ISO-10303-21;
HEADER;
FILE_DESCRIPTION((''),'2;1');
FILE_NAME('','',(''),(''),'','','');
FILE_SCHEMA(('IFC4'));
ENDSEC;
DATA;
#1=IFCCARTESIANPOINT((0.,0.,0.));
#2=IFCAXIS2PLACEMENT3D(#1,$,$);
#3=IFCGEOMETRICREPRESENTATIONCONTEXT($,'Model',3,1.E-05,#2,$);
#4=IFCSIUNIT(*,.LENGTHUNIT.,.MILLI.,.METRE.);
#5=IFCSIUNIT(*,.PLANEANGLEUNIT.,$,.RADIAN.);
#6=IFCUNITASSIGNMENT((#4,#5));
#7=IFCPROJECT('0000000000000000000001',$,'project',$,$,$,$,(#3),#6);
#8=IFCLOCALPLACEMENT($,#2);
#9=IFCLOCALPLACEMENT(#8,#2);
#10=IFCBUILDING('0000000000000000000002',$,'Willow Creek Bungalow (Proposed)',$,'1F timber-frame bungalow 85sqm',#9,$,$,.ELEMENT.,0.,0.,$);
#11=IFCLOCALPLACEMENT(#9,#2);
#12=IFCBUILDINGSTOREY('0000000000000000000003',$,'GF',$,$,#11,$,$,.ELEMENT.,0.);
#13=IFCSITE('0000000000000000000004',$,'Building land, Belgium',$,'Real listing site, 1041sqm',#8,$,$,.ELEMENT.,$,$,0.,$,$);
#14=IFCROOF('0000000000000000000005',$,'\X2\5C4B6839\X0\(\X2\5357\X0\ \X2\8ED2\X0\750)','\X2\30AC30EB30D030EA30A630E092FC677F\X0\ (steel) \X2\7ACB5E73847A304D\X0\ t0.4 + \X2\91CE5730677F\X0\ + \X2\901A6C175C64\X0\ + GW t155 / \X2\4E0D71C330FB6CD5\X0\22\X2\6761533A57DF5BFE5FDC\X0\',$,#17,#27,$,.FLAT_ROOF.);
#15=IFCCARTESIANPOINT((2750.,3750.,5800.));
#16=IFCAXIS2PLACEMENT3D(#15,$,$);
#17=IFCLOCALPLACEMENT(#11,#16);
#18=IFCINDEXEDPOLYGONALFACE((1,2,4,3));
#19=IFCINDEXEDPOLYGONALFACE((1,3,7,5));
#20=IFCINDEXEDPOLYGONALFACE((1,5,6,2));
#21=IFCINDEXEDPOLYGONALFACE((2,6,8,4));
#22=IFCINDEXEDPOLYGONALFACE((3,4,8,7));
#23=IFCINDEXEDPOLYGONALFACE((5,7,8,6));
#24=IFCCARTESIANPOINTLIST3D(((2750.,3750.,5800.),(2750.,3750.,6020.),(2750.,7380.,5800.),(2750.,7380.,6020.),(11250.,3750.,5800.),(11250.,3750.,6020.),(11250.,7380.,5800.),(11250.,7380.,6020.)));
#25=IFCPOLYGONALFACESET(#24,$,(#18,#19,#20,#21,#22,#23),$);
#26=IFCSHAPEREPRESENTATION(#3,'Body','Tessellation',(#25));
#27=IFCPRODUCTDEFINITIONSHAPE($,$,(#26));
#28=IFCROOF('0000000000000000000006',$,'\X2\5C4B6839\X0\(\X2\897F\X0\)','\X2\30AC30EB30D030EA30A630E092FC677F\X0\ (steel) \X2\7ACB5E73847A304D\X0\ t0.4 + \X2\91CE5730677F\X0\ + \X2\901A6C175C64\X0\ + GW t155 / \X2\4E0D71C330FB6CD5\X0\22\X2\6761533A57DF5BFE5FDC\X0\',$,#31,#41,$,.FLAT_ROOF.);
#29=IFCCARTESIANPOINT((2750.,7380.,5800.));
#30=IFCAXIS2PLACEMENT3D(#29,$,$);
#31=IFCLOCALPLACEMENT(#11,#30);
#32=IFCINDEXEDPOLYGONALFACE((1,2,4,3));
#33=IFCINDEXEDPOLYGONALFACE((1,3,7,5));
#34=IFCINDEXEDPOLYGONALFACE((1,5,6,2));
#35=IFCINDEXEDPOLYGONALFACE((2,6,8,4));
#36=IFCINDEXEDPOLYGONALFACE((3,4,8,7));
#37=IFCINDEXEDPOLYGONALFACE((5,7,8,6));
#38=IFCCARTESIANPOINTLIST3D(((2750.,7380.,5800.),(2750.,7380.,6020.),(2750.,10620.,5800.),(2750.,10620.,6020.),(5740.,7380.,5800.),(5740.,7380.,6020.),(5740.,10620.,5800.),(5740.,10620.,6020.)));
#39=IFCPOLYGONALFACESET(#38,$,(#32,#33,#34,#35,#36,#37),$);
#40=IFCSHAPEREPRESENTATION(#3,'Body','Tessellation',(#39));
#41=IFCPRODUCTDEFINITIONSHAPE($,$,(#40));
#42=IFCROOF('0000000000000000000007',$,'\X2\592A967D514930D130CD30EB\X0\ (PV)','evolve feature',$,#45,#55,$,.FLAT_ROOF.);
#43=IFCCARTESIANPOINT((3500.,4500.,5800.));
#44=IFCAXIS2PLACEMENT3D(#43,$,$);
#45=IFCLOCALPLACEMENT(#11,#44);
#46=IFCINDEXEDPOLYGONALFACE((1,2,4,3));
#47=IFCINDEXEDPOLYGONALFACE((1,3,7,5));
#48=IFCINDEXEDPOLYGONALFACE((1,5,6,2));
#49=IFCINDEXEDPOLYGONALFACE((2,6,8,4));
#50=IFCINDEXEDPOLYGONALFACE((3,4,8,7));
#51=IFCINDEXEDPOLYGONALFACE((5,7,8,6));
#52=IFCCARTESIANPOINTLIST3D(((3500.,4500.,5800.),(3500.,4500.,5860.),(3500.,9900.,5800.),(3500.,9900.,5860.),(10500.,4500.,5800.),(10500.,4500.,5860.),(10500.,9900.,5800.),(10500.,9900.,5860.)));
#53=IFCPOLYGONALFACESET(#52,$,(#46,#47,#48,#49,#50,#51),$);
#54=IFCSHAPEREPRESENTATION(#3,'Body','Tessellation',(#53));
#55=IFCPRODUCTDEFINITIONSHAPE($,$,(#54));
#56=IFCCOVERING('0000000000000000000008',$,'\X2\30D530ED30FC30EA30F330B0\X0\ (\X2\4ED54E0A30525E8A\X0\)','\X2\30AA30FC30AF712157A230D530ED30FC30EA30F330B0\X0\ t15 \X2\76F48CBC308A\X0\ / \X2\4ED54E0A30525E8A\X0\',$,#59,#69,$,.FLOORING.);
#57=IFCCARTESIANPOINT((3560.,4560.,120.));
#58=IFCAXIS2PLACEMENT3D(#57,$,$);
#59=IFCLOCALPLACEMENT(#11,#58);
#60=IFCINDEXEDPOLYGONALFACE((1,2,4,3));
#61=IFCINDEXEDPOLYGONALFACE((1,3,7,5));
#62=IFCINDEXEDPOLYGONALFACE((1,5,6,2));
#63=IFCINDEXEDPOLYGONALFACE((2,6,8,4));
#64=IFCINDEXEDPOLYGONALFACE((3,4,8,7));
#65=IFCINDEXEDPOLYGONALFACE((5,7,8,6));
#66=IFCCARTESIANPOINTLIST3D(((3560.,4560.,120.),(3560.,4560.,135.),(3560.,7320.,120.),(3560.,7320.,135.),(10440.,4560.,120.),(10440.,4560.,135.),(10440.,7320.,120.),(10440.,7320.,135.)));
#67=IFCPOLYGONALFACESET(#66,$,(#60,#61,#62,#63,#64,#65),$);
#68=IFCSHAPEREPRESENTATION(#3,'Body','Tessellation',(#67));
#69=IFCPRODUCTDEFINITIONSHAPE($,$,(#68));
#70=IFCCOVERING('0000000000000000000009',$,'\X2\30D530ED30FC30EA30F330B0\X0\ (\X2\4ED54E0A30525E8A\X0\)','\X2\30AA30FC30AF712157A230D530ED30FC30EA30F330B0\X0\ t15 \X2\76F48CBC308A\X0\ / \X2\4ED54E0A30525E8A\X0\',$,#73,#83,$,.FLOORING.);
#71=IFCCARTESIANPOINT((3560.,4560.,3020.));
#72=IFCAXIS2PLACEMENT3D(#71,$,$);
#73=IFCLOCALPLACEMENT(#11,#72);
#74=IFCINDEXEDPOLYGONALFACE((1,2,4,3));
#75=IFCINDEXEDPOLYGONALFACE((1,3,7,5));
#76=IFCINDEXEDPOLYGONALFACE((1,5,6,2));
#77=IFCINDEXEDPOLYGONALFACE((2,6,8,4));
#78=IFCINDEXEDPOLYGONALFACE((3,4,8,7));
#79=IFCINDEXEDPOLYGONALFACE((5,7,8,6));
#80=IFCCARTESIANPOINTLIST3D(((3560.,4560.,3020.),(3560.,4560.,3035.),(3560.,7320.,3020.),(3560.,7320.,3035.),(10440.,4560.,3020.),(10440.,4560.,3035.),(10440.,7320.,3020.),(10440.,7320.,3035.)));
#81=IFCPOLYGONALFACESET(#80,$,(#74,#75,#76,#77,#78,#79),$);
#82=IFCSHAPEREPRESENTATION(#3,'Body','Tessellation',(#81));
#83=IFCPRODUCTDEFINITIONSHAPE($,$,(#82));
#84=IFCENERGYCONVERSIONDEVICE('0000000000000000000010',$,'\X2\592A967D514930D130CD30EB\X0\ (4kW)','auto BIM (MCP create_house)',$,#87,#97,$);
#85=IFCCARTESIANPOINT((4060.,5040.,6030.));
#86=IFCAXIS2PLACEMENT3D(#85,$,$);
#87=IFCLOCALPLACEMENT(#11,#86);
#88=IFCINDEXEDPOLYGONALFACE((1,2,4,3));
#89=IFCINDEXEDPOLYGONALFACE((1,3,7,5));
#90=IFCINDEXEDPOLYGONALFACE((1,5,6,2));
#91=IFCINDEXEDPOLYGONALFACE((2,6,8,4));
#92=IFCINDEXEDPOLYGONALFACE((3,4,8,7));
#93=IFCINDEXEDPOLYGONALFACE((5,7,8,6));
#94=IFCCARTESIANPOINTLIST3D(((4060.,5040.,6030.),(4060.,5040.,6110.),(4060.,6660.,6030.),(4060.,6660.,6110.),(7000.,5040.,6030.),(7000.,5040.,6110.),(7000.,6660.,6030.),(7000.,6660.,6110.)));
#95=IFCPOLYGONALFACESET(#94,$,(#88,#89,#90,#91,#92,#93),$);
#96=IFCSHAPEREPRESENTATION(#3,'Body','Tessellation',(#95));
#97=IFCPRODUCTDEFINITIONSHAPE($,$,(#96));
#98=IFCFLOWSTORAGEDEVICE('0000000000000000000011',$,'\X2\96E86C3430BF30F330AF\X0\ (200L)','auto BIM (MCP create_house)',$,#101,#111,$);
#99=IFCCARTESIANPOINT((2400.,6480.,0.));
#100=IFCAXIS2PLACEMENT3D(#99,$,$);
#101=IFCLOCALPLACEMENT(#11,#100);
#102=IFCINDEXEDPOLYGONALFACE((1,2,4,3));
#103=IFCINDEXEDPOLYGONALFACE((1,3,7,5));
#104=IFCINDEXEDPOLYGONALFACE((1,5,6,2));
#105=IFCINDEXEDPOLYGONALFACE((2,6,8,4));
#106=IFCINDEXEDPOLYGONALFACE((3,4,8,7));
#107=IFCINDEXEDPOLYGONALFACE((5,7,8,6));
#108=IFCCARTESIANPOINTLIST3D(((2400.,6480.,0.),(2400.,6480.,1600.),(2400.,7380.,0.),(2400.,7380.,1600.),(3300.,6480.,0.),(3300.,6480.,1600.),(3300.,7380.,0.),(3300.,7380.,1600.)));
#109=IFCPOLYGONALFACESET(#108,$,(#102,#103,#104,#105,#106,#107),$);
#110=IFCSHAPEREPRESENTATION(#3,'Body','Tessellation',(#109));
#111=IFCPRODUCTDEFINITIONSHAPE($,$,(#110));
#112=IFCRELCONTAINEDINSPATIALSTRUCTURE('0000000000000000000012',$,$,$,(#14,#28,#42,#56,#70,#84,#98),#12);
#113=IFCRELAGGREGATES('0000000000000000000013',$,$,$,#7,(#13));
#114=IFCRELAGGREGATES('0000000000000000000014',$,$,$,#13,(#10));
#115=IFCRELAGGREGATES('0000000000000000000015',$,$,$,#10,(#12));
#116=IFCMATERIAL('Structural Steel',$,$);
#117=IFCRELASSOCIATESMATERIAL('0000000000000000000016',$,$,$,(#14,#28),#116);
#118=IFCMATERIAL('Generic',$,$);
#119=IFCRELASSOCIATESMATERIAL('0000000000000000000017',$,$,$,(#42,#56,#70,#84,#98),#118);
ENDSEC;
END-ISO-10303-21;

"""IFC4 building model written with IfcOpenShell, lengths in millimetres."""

from ifc_helpers import new_model, si_unit, frame, frame_2d, origin, place, context, project, spatial, rectangle, extrude, material, element, save


model = new_model("IFC4")

# Units and contexts
model_context = context("Model", 3, precision=1e-05, world=origin())
ifc_project = project(units=[si_unit("LENGTHUNIT", "METRE", prefix="MILLI"), si_unit("PLANEANGLEUNIT", "RADIAN")], contexts=[model_context])

# Site, building, storey
site_placement = place(None, origin())
site = spatial("IfcSite", under=ifc_project, at=site_placement, Name="Building land, Belgium", ObjectType="Real listing site, 1041sqm", CompositionType="ELEMENT", RefElevation=0.0)
building_placement = place(site_placement, origin())
building = spatial("IfcBuilding", under=site, at=building_placement, Name="Willow Creek Bungalow (Proposed)", ObjectType="1F timber-frame bungalow 85sqm", CompositionType="ELEMENT", ElevationOfRefHeight=0.0, ElevationOfTerrain=0.0)
storey_placement = place(building_placement, origin())
storey = spatial("IfcBuildingStorey", under=building, at=storey_placement, Name="GF", CompositionType="ELEMENT", Elevation=0.0)

# Shared definitions
ifc_material_1 = material(Name="Generic")

# Roofs
ifc_material_2 = material(Name="Structural Steel")
roof_1_placement = place(storey_placement, frame((2750.0, 3750.0, 5800.0)))
element("IfcRoof", 1, at=roof_1_placement, inside=storey, material=ifc_material_2, Name="屋根(南 軒750)", Description="ガルバリウム鋼板 (steel) 立平葺き t0.4 + 野地板 + 通気層 + GW t155 / 不燃・法22条区域対応", PredefinedType="FLAT_ROOF", context=model_context, shape_type="SweptSolid", body=[
    extrude(rectangle(XDim=8500.0, YDim=3630.0, at=frame_2d((4250.0, 1815.0))), frame((2750.0, 3750.0, 5800.0)), (0.0, 0.0, 1.0), 220.0),
])
roof_2_placement = place(storey_placement, frame((2750.0, 7380.0, 5800.0)))
element("IfcRoof", 2, at=roof_2_placement, inside=storey, material=ifc_material_2, Name="屋根(西)", Description="ガルバリウム鋼板 (steel) 立平葺き t0.4 + 野地板 + 通気層 + GW t155 / 不燃・法22条区域対応", PredefinedType="FLAT_ROOF", context=model_context, shape_type="SweptSolid", body=[
    extrude(rectangle(XDim=2990.0, YDim=3240.0, at=frame_2d((1495.0, 1620.0))), frame((2750.0, 7380.0, 5800.0)), (0.0, 0.0, 1.0), 220.0),
])
roof_3_placement = place(storey_placement, frame((3500.0, 4500.0, 5800.0)))
element("IfcRoof", 3, at=roof_3_placement, inside=storey, material=ifc_material_1, Name="太陽光パネル (PV)", Description="evolve feature", PredefinedType="FLAT_ROOF", context=model_context, shape_type="SweptSolid", body=[
    extrude(rectangle(XDim=7000.0, YDim=5400.0, at=frame_2d((3500.0, 2700.0))), frame((3500.0, 4500.0, 5800.0)), (0.0, 0.0, 1.0), 60.0),
])

# Coverings
covering_1_placement = place(storey_placement, frame((3560.0, 4560.0, 120.0)))
element("IfcCovering", 4, at=covering_1_placement, inside=storey, material=ifc_material_1, Name="フローリング (仕上げ床)", Description="オーク無垢フローリング t15 直貼り / 仕上げ床", PredefinedType="FLOORING", context=model_context, shape_type="SweptSolid", body=[
    extrude(rectangle(XDim=6880.0, YDim=2760.0, at=frame_2d((3440.0, 1380.0))), frame((3560.0, 4560.0, 120.0)), (0.0, 0.0, 1.0), 15.0),
])
covering_2_placement = place(storey_placement, frame((3560.0, 4560.0, 3020.0)))
element("IfcCovering", 5, at=covering_2_placement, inside=storey, material=ifc_material_1, Name="フローリング (仕上げ床)", Description="オーク無垢フローリング t15 直貼り / 仕上げ床", PredefinedType="FLOORING", context=model_context, shape_type="SweptSolid", body=[
    extrude(rectangle(XDim=6880.0, YDim=2760.0, at=frame_2d((3440.0, 1380.0))), frame((3560.0, 4560.0, 3020.0)), (0.0, 0.0, 1.0), 15.0),
])

# Energy conversion device
energy_conversion_device_placement = place(storey_placement, frame((4060.0, 5040.0, 6030.0)))
element("IfcEnergyConversionDevice", 6, at=energy_conversion_device_placement, inside=storey, material=ifc_material_1, Name="太陽光パネル (4kW)", Description="auto BIM (MCP create_house)", context=model_context, shape_type="SweptSolid", body=[
    extrude(rectangle(XDim=2940.0, YDim=1620.0, at=frame_2d((1470.0, 810.0))), frame((4060.0, 5040.0, 6030.0)), (0.0, 0.0, 1.0), 80.0),
])

# Flow storage device
flow_storage_device_placement = place(storey_placement, frame((2400.0, 6480.0, 0.0)))
element("IfcFlowStorageDevice", 7, at=flow_storage_device_placement, inside=storey, material=ifc_material_1, Name="雨水タンク (200L)", Description="auto BIM (MCP create_house)", context=model_context, shape_type="SweptSolid", body=[
    extrude(rectangle(XDim=900.0, YDim=900.0, at=frame_2d((450.0, 450.0))), frame((2400.0, 6480.0, 0.0)), (0.0, 0.0, 1.0), 1600.0),
])

save(model, "model.ifc")
